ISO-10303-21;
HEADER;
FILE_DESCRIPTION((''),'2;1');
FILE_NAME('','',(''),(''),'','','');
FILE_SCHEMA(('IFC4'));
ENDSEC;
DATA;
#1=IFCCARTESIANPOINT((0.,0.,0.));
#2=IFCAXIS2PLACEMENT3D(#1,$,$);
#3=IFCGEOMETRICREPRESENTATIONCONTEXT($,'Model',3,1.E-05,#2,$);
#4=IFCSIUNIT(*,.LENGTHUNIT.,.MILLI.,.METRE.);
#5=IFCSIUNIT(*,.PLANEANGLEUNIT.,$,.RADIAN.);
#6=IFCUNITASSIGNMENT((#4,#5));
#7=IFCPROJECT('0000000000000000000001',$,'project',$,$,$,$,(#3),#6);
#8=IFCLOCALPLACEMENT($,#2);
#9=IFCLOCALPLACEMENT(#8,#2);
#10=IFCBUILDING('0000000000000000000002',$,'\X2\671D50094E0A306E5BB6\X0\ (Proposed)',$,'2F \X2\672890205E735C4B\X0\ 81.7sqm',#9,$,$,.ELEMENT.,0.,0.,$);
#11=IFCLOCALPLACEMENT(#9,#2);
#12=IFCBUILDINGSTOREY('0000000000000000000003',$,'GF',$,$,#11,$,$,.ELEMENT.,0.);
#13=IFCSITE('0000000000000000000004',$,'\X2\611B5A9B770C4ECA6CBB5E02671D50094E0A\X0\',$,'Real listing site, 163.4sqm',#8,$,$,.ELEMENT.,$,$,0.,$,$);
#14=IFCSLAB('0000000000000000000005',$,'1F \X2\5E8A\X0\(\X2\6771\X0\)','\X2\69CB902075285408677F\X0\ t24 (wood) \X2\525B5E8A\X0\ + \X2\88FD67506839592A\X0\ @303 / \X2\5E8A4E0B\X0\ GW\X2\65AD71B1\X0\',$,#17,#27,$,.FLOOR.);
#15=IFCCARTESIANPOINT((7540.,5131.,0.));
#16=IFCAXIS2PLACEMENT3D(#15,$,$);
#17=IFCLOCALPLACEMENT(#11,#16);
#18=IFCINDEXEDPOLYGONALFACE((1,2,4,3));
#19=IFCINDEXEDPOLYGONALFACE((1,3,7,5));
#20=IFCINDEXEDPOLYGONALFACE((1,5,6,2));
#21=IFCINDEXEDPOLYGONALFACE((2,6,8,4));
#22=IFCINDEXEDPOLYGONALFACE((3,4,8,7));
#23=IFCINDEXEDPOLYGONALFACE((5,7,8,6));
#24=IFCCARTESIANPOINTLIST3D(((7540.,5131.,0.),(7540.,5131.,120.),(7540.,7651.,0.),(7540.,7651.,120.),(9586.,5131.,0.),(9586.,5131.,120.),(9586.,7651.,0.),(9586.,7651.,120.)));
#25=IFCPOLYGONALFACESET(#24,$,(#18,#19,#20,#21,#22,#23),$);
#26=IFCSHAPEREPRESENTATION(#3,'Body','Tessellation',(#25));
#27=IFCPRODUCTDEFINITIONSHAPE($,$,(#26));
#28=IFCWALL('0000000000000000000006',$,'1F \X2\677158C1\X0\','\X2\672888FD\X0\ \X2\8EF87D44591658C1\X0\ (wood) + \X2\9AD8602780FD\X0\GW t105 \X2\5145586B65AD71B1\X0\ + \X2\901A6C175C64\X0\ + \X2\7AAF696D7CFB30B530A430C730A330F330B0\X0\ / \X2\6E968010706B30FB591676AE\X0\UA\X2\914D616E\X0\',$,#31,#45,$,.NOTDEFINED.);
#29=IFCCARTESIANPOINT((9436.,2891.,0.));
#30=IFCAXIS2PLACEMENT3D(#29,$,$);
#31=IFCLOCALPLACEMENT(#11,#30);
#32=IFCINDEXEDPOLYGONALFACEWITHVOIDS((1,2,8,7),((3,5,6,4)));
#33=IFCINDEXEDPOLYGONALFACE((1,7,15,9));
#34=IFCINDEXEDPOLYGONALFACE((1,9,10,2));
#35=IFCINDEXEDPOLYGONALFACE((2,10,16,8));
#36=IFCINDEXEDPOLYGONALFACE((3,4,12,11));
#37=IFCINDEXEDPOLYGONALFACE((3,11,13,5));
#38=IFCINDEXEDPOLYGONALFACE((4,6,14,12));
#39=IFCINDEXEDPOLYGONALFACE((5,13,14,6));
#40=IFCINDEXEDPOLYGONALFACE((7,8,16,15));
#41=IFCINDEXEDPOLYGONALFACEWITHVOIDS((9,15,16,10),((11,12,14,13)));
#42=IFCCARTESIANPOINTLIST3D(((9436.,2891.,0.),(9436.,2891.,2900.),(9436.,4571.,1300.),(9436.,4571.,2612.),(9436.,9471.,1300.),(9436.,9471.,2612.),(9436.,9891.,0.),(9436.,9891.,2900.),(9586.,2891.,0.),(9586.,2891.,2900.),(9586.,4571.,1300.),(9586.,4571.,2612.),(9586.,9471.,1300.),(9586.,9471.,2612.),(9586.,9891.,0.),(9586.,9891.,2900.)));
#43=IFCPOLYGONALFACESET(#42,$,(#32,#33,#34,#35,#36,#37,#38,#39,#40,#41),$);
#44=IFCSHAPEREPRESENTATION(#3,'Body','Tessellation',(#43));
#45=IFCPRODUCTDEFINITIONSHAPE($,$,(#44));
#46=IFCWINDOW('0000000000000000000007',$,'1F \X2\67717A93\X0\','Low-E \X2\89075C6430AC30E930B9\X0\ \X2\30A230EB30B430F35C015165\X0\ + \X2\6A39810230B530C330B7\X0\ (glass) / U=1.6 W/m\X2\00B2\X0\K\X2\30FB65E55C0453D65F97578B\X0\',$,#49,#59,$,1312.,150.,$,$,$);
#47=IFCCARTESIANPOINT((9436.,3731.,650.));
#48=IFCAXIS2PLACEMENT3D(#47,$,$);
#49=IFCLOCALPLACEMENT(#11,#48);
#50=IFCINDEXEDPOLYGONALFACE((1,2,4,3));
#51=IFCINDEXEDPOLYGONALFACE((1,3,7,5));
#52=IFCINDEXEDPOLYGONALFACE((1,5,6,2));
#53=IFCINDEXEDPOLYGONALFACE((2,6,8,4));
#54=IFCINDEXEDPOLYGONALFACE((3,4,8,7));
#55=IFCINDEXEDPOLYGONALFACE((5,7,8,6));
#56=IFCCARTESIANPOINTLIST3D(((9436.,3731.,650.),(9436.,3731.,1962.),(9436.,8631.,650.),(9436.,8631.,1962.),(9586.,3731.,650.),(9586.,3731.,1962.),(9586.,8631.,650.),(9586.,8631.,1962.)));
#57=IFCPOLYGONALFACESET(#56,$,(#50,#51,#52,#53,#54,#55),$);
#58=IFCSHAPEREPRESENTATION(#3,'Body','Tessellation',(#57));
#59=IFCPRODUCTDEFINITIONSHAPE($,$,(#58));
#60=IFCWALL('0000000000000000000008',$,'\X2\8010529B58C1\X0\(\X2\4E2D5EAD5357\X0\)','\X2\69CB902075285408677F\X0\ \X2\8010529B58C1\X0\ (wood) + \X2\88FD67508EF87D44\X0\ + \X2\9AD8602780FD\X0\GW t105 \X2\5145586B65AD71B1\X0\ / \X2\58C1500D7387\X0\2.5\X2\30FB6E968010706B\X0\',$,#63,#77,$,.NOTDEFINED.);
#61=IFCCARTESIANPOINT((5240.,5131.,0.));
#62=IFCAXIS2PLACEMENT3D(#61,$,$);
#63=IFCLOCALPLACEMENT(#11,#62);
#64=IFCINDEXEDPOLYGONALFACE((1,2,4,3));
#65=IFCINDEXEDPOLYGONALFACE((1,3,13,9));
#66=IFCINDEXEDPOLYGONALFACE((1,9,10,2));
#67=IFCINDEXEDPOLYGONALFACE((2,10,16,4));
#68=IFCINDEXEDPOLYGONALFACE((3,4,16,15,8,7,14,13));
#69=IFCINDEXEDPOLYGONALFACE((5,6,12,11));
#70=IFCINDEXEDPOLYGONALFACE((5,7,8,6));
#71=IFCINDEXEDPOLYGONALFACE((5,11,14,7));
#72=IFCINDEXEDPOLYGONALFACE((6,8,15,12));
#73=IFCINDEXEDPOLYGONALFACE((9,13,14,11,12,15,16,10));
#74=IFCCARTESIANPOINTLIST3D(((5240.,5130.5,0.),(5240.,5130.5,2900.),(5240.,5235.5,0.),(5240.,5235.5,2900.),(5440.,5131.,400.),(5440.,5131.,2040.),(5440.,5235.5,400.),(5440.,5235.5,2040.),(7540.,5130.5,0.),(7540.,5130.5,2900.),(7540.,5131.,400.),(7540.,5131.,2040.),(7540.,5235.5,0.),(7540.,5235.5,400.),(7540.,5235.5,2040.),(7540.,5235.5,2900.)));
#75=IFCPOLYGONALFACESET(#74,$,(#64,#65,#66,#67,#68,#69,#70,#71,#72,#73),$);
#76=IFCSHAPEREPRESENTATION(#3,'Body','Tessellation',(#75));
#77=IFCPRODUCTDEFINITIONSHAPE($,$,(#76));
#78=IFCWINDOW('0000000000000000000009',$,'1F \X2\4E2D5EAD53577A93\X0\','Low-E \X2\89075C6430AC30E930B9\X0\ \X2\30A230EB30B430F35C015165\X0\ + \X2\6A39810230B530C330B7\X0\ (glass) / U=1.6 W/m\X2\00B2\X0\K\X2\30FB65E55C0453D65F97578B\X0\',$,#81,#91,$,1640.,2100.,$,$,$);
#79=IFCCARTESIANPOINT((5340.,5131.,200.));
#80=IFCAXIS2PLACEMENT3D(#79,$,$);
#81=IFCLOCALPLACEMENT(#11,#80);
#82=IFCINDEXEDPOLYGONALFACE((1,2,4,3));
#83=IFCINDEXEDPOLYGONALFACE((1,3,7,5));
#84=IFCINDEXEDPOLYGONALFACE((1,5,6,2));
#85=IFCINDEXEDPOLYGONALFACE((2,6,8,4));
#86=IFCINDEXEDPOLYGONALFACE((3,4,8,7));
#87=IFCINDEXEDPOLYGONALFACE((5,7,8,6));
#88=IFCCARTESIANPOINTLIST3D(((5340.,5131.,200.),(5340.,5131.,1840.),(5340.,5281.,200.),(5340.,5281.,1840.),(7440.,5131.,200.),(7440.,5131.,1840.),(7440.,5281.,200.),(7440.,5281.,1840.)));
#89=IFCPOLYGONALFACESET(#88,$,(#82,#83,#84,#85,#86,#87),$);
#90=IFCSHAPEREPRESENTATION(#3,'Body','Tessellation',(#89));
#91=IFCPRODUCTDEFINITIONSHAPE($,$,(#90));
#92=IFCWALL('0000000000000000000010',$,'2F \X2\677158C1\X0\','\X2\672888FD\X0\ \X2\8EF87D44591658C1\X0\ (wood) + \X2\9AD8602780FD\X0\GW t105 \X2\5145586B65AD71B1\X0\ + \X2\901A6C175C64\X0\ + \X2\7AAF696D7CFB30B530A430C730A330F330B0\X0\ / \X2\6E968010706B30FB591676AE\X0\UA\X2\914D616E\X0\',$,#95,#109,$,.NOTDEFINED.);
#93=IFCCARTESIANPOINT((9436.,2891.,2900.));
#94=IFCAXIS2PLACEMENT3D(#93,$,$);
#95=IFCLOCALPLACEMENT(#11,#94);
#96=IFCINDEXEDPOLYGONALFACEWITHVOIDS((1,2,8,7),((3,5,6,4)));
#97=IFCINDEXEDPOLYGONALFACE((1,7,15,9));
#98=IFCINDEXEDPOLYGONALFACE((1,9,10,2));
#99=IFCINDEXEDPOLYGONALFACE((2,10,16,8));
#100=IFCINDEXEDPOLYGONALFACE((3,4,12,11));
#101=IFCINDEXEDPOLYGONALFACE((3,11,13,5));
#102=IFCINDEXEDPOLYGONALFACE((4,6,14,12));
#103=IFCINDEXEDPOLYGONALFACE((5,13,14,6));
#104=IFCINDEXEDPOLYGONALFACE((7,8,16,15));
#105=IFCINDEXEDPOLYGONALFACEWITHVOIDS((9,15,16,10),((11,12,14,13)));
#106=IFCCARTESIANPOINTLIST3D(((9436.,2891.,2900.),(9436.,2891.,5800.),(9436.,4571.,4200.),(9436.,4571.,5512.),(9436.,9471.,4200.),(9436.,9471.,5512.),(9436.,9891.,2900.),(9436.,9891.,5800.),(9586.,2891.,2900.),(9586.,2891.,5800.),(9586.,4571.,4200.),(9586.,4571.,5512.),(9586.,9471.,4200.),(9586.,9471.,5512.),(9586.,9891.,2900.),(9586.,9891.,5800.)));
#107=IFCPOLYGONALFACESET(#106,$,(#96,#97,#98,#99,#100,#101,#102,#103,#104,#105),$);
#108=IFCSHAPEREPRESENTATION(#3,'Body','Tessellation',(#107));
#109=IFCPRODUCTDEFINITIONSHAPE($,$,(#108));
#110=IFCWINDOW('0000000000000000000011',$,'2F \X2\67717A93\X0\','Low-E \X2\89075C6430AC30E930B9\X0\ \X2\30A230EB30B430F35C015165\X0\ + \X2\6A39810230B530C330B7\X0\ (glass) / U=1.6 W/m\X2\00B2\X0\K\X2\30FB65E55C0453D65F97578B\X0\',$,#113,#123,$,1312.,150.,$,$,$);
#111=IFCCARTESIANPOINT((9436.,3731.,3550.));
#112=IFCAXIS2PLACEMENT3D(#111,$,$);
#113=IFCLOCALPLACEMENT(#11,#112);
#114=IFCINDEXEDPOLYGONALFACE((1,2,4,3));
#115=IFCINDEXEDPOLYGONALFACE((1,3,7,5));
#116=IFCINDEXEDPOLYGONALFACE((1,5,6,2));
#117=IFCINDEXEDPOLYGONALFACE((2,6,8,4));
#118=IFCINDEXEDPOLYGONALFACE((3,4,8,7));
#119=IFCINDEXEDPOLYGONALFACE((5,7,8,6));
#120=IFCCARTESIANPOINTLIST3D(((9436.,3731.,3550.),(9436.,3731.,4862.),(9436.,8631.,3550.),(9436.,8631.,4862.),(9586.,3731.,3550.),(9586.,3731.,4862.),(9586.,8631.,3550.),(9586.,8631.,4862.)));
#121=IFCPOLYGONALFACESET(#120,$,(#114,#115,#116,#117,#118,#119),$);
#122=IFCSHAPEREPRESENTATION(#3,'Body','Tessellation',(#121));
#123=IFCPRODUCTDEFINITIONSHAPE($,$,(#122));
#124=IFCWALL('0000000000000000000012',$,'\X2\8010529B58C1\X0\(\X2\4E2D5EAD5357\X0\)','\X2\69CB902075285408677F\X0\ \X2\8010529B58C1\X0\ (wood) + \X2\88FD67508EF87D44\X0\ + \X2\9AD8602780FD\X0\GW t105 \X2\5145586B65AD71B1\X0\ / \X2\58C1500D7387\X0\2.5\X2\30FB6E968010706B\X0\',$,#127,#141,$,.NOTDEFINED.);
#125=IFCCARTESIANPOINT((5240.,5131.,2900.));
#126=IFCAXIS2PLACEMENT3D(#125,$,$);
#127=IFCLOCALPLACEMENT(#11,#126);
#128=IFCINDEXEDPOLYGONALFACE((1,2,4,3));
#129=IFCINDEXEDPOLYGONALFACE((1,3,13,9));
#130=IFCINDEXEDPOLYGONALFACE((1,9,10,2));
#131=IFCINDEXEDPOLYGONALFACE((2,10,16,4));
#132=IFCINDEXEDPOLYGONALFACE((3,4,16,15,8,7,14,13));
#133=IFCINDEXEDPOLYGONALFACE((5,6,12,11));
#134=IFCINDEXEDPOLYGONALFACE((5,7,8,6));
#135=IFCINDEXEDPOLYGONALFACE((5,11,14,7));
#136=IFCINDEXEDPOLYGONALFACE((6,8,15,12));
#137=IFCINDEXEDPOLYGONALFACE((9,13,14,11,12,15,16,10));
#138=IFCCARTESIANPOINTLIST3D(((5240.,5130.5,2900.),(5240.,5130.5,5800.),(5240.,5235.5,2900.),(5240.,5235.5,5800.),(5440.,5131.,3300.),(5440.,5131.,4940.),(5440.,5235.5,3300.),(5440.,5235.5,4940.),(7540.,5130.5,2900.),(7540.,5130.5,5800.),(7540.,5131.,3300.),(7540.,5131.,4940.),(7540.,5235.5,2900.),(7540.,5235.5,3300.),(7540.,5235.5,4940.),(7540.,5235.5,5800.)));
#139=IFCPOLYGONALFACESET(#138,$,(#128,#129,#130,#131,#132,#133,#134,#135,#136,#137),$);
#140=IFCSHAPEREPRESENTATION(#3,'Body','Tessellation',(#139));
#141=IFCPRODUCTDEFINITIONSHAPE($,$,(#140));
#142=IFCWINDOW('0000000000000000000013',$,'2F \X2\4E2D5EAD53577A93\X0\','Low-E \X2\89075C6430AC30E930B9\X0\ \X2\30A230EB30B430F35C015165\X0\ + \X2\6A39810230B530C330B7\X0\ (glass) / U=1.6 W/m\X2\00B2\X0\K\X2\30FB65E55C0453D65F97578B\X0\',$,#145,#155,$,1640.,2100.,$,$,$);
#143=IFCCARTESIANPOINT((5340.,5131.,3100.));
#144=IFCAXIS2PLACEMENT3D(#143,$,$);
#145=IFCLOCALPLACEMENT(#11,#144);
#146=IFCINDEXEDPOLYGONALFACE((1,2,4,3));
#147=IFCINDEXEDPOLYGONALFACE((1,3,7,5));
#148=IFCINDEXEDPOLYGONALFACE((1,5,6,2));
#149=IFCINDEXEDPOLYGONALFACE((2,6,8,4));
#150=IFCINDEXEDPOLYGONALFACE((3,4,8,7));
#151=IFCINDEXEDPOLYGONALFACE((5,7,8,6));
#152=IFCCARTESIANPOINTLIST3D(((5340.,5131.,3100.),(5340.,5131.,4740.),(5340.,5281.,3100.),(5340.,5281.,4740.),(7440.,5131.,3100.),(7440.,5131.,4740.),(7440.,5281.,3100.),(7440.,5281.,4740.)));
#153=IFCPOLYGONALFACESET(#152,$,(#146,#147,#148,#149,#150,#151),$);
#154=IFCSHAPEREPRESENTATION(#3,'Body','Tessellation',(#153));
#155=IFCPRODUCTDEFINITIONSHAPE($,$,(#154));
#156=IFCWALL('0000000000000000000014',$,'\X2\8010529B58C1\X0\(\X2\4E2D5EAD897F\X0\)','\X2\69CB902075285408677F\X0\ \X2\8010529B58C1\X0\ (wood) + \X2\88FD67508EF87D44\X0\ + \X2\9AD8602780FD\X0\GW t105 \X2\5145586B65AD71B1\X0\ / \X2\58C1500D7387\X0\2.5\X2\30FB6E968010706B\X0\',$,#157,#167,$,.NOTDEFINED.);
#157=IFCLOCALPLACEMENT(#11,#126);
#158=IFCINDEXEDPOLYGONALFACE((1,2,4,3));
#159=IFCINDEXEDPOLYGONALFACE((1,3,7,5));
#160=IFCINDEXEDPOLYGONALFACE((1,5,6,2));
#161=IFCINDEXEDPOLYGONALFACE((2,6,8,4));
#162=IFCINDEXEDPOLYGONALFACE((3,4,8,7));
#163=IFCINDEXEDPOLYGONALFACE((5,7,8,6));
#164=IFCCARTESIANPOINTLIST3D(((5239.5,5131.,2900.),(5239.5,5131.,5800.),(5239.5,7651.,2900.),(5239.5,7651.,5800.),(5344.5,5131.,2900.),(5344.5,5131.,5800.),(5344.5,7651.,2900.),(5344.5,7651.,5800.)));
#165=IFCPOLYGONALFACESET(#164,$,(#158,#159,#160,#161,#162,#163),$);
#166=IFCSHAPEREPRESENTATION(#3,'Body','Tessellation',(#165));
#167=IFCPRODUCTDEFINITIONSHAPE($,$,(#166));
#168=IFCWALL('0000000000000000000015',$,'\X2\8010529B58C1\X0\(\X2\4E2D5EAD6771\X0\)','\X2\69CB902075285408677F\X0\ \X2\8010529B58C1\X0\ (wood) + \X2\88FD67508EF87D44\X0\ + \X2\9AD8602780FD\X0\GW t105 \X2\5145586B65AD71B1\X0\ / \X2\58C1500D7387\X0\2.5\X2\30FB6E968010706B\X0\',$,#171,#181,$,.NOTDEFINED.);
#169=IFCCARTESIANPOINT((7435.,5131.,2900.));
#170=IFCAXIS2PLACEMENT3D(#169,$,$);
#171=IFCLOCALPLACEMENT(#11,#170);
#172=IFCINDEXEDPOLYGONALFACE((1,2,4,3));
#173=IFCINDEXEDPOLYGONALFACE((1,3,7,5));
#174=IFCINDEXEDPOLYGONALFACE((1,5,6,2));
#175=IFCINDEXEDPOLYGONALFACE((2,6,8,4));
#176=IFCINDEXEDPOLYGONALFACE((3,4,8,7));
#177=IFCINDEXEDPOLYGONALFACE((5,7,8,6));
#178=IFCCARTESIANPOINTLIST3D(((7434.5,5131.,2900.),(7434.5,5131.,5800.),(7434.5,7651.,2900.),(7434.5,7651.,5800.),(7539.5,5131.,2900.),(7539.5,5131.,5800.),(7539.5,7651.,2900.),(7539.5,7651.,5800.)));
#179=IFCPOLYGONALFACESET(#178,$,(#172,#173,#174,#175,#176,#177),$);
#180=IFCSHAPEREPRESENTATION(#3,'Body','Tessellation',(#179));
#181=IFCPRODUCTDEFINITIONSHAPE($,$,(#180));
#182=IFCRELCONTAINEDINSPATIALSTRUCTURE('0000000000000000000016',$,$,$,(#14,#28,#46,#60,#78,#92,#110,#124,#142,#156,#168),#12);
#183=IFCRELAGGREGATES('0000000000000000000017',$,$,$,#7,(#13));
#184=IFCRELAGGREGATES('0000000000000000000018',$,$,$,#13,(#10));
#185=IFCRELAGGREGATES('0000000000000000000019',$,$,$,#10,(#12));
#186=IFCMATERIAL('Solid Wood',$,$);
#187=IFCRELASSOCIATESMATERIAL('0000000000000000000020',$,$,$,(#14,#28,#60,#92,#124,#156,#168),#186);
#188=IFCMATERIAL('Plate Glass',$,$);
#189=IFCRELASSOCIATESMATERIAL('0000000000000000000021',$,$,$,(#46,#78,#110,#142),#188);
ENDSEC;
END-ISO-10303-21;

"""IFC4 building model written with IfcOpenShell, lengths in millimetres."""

from ifc_helpers import new_model, si_unit, frame, frame_2d, origin, place, context, project, spatial, rectangle, extrude, material, element, fill, save


model = new_model("IFC4")

# Units and contexts
model_context = context("Model", 3, precision=1e-05, world=origin())
ifc_project = project(units=[si_unit("LENGTHUNIT", "METRE", prefix="MILLI"), si_unit("PLANEANGLEUNIT", "RADIAN")], contexts=[model_context])

# Site, building, storey
site_placement = place(None, origin())
site = spatial("IfcSite", under=ifc_project, at=site_placement, Name="愛媛県今治市朝倉上", ObjectType="Real listing site, 163.4sqm", CompositionType="ELEMENT", RefElevation=0.0)
building_placement = place(site_placement, origin())
building = spatial("IfcBuilding", under=site, at=building_placement, Name="朝倉上の家 (Proposed)", ObjectType="2F 木造平屋 81.7sqm", CompositionType="ELEMENT", ElevationOfRefHeight=0.0, ElevationOfTerrain=0.0)
storey_placement = place(building_placement, origin())
storey = spatial("IfcBuildingStorey", under=building, at=storey_placement, Name="GF", CompositionType="ELEMENT", Elevation=0.0)

# Slab
ifc_material_1 = material(Name="Solid Wood")
slab_placement = place(storey_placement, frame((7540.0, 5131.0, 0.0)))
element("IfcSlab", 1, at=slab_placement, inside=storey, material=ifc_material_1, Name="1F 床(東)", Description="構造用合板 t24 (wood) 剛床 + 製材根太 @303 / 床下 GW断熱", PredefinedType="FLOOR", context=model_context, shape_type="SweptSolid", body=[
    extrude(rectangle(XDim=2046.0, YDim=2520.0, at=frame_2d((1023.0, 1260.0))), frame((7540.0, 5131.0, 0.0)), (0.0, 0.0, 1.0), 120.0),
])

# Walls, openings, windows
wall_1_placement = place(storey_placement, frame((9436.0, 2891.0, 0.0)))
wall_1 = element("IfcWall", 2, at=wall_1_placement, inside=storey, material=ifc_material_1, Name="1F 東壁", Description="木製 軸組外壁 (wood) + 高性能GW t105 充填断熱 + 通気層 + 窯業系サイディング / 準耐火・外皮UA配慮", PredefinedType="NOTDEFINED", context=model_context, shape_type="SweptSolid", body=[
    extrude(rectangle(XDim=150.0, YDim=7000.0, at=frame_2d((75.0, 3500.0))), frame((9436.0, 2891.0, 0.0)), (0.0, 0.0, 1.0), 2900.0),
])
opening_1_placement = place(storey_placement, frame((9436.0, 3731.0, 650.0)))
opening_1 = element("IfcOpeningElement", 3, at=opening_1_placement, cuts=wall_1, PredefinedType="NOTDEFINED", context=model_context, shape_type="SweptSolid", body=[
    extrude(rectangle(XDim=150.0, YDim=4900.0, at=frame_2d((75.0, 2450.0))), frame((9436.0, 3731.0, 650.0)), (0.0, 0.0, 1.0), 1312.0),
])
ifc_material_2 = material(Name="Plate Glass")
window_1_placement = place(storey_placement, frame((9436.0, 3731.0, 650.0)))
window_1 = element("IfcWindow", 4, at=window_1_placement, inside=storey, material=ifc_material_2, Name="1F 東窓", Description="Low-E 複層ガラス アルゴン封入 + 樹脂サッシ (glass) / U=1.6 W/m²K・日射取得型", OverallHeight=1312.0, OverallWidth=150.0, context=model_context, shape_type="SweptSolid", body=[
    extrude(rectangle(XDim=150.0, YDim=4900.0, at=frame_2d((75.0, 2450.0))), frame((9436.0, 3731.0, 650.0)), (0.0, 0.0, 1.0), 1312.0),
])
fill(opening_1, window_1)
wall_2_placement = place(storey_placement, frame((5240.0, 5131.0, 0.0)))
wall_2 = element("IfcWall", 5, at=wall_2_placement, inside=storey, material=ifc_material_1, Name="耐力壁(中庭南)", Description="構造用合板 耐力壁 (wood) + 製材軸組 + 高性能GW t105 充填断熱 / 壁倍率2.5・準耐火", PredefinedType="NOTDEFINED", context=model_context, shape_type="SweptSolid", body=[
    extrude(rectangle(XDim=2300.0, YDim=105.0, at=frame_2d((1150.0, 52.0))), frame((5240.0, 5131.0, 0.0)), (0.0, 0.0, 1.0), 2900.0),
])
opening_2_placement = place(storey_placement, frame((5340.0, 5131.0, 200.0)))
opening_2 = element("IfcOpeningElement", 6, at=opening_2_placement, cuts=wall_2, PredefinedType="NOTDEFINED", context=model_context, shape_type="SweptSolid", body=[
    extrude(rectangle(XDim=2100.0, YDim=150.0, at=frame_2d((1050.0, 75.0))), frame((5340.0, 5131.0, 200.0)), (0.0, 0.0, 1.0), 1640.0),
])
window_2_placement = place(storey_placement, frame((5340.0, 5131.0, 200.0)))
window_2 = element("IfcWindow", 7, at=window_2_placement, inside=storey, material=ifc_material_2, Name="1F 中庭南窓", Description="Low-E 複層ガラス アルゴン封入 + 樹脂サッシ (glass) / U=1.6 W/m²K・日射取得型", OverallHeight=1640.0, OverallWidth=2100.0, context=model_context, shape_type="SweptSolid", body=[
    extrude(rectangle(XDim=2100.0, YDim=150.0, at=frame_2d((1050.0, 75.0))), frame((5340.0, 5131.0, 200.0)), (0.0, 0.0, 1.0), 1640.0),
])
fill(opening_2, window_2)

# Walls, openings, windows
wall_3_placement = place(storey_placement, frame((9436.0, 2891.0, 2900.0)))
wall_3 = element("IfcWall", 8, at=wall_3_placement, inside=storey, material=ifc_material_1, Name="2F 東壁", Description="木製 軸組外壁 (wood) + 高性能GW t105 充填断熱 + 通気層 + 窯業系サイディング / 準耐火・外皮UA配慮", PredefinedType="NOTDEFINED", context=model_context, shape_type="SweptSolid", body=[
    extrude(rectangle(XDim=150.0, YDim=7000.0, at=frame_2d((75.0, 3500.0))), frame((9436.0, 2891.0, 2900.0)), (0.0, 0.0, 1.0), 2900.0),
])
opening_3_placement = place(storey_placement, frame((9436.0, 3731.0, 3550.0)))
opening_3 = element("IfcOpeningElement", 9, at=opening_3_placement, cuts=wall_3, PredefinedType="NOTDEFINED", context=model_context, shape_type="SweptSolid", body=[
    extrude(rectangle(XDim=150.0, YDim=4900.0, at=frame_2d((75.0, 2450.0))), frame((9436.0, 3731.0, 3550.0)), (0.0, 0.0, 1.0), 1312.0),
])
window_3_placement = place(storey_placement, frame((9436.0, 3731.0, 3550.0)))
window_3 = element("IfcWindow", 10, at=window_3_placement, inside=storey, material=ifc_material_2, Name="2F 東窓", Description="Low-E 複層ガラス アルゴン封入 + 樹脂サッシ (glass) / U=1.6 W/m²K・日射取得型", OverallHeight=1312.0, OverallWidth=150.0, context=model_context, shape_type="SweptSolid", body=[
    extrude(rectangle(XDim=150.0, YDim=4900.0, at=frame_2d((75.0, 2450.0))), frame((9436.0, 3731.0, 3550.0)), (0.0, 0.0, 1.0), 1312.0),
])
fill(opening_3, window_3)
wall_4_placement = place(storey_placement, frame((5240.0, 5131.0, 2900.0)))
wall_4 = element("IfcWall", 11, at=wall_4_placement, inside=storey, material=ifc_material_1, Name="耐力壁(中庭南)", Description="構造用合板 耐力壁 (wood) + 製材軸組 + 高性能GW t105 充填断熱 / 壁倍率2.5・準耐火", PredefinedType="NOTDEFINED", context=model_context, shape_type="SweptSolid", body=[
    extrude(rectangle(XDim=2300.0, YDim=105.0, at=frame_2d((1150.0, 52.0))), frame((5240.0, 5131.0, 2900.0)), (0.0, 0.0, 1.0), 2900.0),
])
opening_4_placement = place(storey_placement, frame((5340.0, 5131.0, 3100.0)))
opening_4 = element("IfcOpeningElement", 12, at=opening_4_placement, cuts=wall_4, PredefinedType="NOTDEFINED", context=model_context, shape_type="SweptSolid", body=[
    extrude(rectangle(XDim=2100.0, YDim=150.0, at=frame_2d((1050.0, 75.0))), frame((5340.0, 5131.0, 3100.0)), (0.0, 0.0, 1.0), 1640.0),
])
window_4_placement = place(storey_placement, frame((5340.0, 5131.0, 3100.0)))
window_4 = element("IfcWindow", 13, at=window_4_placement, inside=storey, material=ifc_material_2, Name="2F 中庭南窓", Description="Low-E 複層ガラス アルゴン封入 + 樹脂サッシ (glass) / U=1.6 W/m²K・日射取得型", OverallHeight=1640.0, OverallWidth=2100.0, context=model_context, shape_type="SweptSolid", body=[
    extrude(rectangle(XDim=2100.0, YDim=150.0, at=frame_2d((1050.0, 75.0))), frame((5340.0, 5131.0, 3100.0)), (0.0, 0.0, 1.0), 1640.0),
])
fill(opening_4, window_4)

# Walls
wall_5_placement = place(storey_placement, frame((5240.0, 5131.0, 2900.0)))
element("IfcWall", 14, at=wall_5_placement, inside=storey, material=ifc_material_1, Name="耐力壁(中庭西)", Description="構造用合板 耐力壁 (wood) + 製材軸組 + 高性能GW t105 充填断熱 / 壁倍率2.5・準耐火", PredefinedType="NOTDEFINED", context=model_context, shape_type="SweptSolid", body=[
    extrude(rectangle(XDim=105.0, YDim=2520.0, at=frame_2d((52.0, 1260.0))), frame((5240.0, 5131.0, 2900.0)), (0.0, 0.0, 1.0), 2900.0),
])
wall_6_placement = place(storey_placement, frame((7435.0, 5131.0, 2900.0)))
element("IfcWall", 15, at=wall_6_placement, inside=storey, material=ifc_material_1, Name="耐力壁(中庭東)", Description="構造用合板 耐力壁 (wood) + 製材軸組 + 高性能GW t105 充填断熱 / 壁倍率2.5・準耐火", PredefinedType="NOTDEFINED", context=model_context, shape_type="SweptSolid", body=[
    extrude(rectangle(XDim=105.0, YDim=2520.0, at=frame_2d((52.0, 1260.0))), frame((7435.0, 5131.0, 2900.0)), (0.0, 0.0, 1.0), 2900.0),
])

save(model, "model.ifc")
